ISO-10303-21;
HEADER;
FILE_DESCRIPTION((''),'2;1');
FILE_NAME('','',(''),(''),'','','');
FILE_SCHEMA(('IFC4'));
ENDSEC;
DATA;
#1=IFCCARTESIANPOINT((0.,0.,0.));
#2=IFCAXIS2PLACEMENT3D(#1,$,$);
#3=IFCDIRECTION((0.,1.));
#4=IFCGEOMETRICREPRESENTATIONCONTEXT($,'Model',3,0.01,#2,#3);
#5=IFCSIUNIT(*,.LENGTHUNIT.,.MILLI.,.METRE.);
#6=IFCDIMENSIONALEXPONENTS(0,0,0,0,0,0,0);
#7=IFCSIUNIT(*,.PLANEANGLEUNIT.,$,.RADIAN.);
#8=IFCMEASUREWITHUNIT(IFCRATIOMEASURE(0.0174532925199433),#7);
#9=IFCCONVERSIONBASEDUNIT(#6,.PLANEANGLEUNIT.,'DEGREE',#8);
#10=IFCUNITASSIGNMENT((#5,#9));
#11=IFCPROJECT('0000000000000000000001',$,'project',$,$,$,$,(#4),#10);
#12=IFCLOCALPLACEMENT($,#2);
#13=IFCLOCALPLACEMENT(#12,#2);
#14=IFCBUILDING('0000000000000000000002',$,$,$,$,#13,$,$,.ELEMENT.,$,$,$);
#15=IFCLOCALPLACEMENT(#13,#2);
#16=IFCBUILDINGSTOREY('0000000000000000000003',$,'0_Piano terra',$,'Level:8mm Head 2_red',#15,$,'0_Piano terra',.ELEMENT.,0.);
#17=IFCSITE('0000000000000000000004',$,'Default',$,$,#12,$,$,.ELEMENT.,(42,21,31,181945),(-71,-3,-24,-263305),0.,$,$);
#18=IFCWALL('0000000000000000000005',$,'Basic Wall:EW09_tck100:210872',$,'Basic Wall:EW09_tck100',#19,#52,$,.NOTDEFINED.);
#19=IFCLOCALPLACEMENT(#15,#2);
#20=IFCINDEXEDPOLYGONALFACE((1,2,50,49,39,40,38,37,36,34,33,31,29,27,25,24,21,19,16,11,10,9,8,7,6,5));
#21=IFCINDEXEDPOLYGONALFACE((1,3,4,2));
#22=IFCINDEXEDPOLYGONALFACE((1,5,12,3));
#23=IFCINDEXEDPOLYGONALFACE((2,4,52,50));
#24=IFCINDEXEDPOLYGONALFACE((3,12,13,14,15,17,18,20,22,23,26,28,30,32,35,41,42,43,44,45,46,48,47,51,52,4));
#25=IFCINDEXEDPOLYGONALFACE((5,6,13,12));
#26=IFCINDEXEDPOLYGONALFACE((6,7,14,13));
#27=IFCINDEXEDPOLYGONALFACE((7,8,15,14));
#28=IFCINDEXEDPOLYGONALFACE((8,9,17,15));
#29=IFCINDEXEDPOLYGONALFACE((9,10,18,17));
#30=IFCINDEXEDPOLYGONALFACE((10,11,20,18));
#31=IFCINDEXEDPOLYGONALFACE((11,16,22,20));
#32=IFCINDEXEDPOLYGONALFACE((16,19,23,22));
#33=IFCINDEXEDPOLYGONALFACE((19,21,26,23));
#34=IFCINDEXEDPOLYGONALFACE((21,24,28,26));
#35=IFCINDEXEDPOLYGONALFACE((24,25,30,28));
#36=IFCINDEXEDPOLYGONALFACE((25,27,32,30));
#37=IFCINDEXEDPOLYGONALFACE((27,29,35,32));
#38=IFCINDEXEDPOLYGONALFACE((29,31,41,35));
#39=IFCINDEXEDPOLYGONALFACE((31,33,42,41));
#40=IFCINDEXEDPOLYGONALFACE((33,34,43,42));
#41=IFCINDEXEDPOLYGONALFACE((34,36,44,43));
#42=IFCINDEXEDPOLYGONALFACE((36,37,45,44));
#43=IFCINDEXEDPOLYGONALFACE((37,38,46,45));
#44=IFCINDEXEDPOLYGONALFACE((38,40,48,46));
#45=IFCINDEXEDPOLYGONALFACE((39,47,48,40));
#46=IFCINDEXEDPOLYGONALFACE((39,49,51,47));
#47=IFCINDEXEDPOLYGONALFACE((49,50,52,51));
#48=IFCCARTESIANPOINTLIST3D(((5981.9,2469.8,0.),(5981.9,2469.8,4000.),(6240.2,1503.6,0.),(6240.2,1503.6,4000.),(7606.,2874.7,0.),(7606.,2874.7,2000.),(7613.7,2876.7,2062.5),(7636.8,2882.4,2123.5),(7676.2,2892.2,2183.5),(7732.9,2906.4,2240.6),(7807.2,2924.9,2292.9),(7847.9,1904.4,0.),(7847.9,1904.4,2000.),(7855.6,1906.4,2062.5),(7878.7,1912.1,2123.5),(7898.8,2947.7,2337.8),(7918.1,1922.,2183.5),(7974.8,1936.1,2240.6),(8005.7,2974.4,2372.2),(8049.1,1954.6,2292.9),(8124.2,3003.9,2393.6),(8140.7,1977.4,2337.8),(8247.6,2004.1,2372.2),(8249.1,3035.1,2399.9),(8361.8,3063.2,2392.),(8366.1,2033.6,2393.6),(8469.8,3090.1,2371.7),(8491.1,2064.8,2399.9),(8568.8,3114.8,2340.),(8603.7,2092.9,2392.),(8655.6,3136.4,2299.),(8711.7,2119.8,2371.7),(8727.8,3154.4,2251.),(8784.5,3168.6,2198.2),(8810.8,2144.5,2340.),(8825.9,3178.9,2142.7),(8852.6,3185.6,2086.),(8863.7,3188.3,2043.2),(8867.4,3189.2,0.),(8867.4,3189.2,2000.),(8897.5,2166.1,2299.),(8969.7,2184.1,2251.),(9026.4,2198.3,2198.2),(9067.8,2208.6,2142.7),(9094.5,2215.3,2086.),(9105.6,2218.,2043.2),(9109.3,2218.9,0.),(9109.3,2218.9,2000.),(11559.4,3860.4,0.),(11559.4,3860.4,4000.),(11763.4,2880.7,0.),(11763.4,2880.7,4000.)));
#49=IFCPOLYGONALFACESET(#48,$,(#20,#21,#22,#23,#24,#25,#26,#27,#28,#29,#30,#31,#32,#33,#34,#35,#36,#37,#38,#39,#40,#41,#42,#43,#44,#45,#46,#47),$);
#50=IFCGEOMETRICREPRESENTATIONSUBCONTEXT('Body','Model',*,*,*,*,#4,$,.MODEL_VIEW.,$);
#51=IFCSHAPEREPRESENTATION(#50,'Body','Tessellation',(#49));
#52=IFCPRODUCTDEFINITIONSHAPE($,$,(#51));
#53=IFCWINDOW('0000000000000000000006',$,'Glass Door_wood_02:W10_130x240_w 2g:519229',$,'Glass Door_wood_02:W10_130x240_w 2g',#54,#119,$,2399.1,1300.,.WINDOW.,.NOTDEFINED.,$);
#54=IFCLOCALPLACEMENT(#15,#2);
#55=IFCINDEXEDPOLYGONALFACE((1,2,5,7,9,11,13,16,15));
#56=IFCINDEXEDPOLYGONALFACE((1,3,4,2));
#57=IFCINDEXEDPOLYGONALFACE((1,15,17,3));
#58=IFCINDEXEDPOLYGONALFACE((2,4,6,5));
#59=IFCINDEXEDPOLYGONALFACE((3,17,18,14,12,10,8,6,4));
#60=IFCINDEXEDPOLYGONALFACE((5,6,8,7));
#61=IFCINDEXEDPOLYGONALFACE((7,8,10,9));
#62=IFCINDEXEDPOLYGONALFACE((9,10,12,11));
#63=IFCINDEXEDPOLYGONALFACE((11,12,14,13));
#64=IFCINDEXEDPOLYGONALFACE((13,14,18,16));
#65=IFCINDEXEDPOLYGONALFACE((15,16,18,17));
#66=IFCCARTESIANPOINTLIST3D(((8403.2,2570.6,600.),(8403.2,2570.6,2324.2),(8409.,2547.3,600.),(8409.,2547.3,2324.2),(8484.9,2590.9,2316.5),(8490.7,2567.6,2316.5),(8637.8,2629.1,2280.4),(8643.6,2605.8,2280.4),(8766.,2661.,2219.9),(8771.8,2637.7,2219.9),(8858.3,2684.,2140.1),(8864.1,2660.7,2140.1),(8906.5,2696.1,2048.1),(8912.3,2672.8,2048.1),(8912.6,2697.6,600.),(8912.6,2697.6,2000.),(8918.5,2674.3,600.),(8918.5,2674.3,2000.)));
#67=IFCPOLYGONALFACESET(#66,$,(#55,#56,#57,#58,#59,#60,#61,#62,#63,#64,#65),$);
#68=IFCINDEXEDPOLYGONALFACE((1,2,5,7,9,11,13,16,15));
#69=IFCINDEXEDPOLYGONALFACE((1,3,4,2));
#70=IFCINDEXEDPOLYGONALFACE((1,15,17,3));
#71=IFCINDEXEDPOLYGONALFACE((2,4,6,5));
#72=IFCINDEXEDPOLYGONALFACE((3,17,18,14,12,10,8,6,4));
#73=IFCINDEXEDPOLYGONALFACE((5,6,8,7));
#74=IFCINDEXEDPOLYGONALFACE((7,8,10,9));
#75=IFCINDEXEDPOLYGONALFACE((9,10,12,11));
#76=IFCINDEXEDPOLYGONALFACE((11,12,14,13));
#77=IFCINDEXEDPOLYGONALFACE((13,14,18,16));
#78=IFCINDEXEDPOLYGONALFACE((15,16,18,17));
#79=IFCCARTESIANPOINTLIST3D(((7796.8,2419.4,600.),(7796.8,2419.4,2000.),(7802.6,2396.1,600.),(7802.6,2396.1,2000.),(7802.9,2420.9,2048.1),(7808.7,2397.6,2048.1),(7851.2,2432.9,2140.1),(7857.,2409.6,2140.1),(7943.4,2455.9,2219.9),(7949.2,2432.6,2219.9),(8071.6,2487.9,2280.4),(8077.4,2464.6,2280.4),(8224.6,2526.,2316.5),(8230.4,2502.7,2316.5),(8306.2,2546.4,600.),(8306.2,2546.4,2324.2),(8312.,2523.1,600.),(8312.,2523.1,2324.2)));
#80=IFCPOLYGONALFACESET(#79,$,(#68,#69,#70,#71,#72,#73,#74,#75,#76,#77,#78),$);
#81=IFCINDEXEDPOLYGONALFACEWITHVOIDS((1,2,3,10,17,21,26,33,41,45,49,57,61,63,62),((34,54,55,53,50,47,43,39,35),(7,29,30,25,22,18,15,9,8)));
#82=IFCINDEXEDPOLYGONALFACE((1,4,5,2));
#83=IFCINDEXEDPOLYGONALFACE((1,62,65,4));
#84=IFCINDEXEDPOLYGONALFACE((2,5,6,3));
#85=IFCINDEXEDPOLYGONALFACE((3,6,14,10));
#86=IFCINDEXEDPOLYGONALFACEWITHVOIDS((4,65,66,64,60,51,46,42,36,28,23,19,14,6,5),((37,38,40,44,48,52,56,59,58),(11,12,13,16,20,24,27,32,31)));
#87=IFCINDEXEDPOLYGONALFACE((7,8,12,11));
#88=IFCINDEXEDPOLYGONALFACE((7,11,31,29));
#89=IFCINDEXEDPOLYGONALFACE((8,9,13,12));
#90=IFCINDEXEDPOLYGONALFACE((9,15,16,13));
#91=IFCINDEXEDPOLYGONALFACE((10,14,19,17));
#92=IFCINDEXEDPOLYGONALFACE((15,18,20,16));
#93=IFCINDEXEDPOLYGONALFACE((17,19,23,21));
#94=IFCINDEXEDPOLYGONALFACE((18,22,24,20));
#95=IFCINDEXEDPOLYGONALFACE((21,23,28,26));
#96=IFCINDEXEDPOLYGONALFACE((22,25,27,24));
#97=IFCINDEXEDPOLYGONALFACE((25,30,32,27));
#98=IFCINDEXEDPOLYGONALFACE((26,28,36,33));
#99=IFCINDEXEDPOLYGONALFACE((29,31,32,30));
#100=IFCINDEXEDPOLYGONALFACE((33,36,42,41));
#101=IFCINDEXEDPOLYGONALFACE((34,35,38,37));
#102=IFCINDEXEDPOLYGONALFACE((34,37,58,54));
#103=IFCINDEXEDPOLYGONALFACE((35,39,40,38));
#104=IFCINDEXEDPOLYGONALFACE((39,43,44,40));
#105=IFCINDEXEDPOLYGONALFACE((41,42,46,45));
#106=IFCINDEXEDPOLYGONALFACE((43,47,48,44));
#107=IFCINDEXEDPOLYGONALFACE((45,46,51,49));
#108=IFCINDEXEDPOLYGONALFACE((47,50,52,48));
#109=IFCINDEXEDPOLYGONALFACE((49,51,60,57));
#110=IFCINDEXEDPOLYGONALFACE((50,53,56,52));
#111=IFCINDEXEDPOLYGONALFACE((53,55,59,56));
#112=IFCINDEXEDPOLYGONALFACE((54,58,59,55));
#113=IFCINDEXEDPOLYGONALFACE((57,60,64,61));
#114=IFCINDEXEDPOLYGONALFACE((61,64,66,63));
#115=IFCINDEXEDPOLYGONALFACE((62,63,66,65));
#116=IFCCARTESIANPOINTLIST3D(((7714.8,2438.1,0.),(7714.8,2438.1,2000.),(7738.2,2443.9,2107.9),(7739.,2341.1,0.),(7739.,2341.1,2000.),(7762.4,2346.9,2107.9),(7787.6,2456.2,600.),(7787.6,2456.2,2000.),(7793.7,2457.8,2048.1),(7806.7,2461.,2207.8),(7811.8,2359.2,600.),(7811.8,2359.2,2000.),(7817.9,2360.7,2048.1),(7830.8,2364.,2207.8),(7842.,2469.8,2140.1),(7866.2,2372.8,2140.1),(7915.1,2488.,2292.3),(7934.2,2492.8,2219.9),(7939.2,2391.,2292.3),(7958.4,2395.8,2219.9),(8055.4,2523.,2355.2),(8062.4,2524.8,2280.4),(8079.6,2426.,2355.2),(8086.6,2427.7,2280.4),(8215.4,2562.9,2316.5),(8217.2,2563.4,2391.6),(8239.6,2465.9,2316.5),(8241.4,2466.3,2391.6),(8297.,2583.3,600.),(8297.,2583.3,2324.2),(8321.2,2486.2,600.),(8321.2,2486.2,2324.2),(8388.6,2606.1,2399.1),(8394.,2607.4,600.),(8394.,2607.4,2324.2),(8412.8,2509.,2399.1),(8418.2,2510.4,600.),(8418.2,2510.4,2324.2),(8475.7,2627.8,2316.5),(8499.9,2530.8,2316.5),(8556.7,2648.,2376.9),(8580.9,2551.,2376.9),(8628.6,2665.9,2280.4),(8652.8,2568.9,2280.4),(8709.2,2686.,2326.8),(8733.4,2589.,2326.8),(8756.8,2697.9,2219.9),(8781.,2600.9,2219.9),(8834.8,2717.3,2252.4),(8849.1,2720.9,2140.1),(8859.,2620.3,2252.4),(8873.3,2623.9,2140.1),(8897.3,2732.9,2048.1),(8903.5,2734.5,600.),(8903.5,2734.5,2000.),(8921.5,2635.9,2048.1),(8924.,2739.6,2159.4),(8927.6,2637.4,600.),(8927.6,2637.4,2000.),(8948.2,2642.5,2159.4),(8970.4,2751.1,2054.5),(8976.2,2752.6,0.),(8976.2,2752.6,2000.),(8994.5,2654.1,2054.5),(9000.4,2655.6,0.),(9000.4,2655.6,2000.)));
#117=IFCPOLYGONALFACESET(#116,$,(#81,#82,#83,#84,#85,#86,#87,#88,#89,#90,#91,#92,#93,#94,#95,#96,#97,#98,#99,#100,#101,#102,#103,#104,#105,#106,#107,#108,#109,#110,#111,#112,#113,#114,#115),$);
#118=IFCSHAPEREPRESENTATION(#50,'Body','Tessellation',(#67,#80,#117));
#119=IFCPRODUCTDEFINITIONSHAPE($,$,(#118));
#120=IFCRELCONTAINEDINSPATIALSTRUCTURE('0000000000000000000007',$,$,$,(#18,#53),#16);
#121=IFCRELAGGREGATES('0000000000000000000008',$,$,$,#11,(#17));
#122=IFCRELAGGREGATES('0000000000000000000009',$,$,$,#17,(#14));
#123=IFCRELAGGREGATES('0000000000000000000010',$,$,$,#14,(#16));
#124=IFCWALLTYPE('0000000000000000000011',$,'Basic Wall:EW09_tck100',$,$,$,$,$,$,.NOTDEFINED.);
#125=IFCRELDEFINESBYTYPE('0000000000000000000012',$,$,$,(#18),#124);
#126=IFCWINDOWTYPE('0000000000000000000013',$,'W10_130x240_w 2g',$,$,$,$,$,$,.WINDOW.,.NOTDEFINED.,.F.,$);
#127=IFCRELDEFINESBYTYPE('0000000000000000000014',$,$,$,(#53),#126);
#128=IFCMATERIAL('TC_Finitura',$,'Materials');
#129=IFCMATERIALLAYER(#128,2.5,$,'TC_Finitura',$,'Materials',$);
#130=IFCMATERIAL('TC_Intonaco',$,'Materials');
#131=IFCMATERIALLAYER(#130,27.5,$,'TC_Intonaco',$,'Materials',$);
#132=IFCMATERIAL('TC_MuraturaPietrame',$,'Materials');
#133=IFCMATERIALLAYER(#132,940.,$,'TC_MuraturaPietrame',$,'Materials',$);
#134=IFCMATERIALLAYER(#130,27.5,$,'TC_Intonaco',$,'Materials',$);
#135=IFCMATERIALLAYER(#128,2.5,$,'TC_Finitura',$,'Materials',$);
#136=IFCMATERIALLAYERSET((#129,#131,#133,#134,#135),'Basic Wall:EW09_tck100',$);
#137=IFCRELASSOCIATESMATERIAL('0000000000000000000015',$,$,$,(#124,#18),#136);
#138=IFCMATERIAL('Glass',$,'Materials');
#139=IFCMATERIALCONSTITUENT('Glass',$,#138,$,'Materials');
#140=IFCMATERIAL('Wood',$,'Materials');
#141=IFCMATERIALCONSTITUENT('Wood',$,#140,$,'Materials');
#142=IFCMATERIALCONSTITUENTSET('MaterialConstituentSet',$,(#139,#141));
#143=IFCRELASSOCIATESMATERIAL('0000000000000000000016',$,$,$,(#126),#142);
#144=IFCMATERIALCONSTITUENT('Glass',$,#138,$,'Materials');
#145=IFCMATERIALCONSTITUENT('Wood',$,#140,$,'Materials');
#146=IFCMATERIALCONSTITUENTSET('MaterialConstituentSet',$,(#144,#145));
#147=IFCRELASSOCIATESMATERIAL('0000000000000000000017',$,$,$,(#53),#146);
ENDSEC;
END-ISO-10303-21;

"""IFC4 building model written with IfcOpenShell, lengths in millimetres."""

from ifc_helpers import new_model, entity, si_unit, converted_unit, direction, frame, frame_2d, origin, place, context, subcontext, project, spatial, polyline, ellipse_curve, parameter, trimmed, segment, composite_curve, outline, extrude, clip, bounded_halfspace, source, transform, mapped, material, layer, layer_set, layer_usage, constituent, constituent_set, type_object, type_shapes, element, fill, save


model = new_model("IFC4")

# Units and contexts
model_context = context("Model", 3, precision=0.01, world=origin(), true_north=direction((0.0, 1.0)))
body_context = subcontext(model_context, "Body", "Model", "MODEL_VIEW")
ifc_project = project(units=[si_unit("LENGTHUNIT", "METRE", prefix="MILLI"), converted_unit("PLANEANGLEUNIT", "DEGREE", entity("IfcRatioMeasure", 0.0174532925199433), si_unit("PLANEANGLEUNIT", "RADIAN"), dimensions=[0, 0, 0, 0, 0, 0, 0])], contexts=[model_context])

# Site, building, storey
site_placement = place(None, origin())
site = spatial("IfcSite", under=ifc_project, at=site_placement, Name="Default", CompositionType="ELEMENT", RefLatitude=(42, 21, 31, 181945), RefLongitude=(-71, -3, -24, -263305), RefElevation=0.0)
building_placement = place(site_placement, origin())
building = spatial("IfcBuilding", under=site, at=building_placement, CompositionType="ELEMENT")
storey_placement = place(building_placement, origin())
storey = spatial("IfcBuildingStorey", under=building, at=storey_placement, Name="0_Piano terra", ObjectType="Level:8mm Head 2_red", LongName="0_Piano terra", CompositionType="ELEMENT", Elevation=0.0)

# Shared definitions
ifc_material_1 = material(Name="TC_Finitura", Category="Materials")
ifc_material_2 = material(Name="TC_Intonaco", Category="Materials")
ifc_material_3 = material(Name="TC_MuraturaPietrame", Category="Materials")
ifc_material_4 = material(Name="Glass", Category="Materials")
ifc_material_5 = material(Name="Wood", Category="Materials")

# Wall, opening, window
ifc_layer_1 = layer(ifc_material_1, 2.5, Name="TC_Finitura", Category="Materials")
ifc_layer_2 = layer(ifc_material_2, 27.5, Name="TC_Intonaco", Category="Materials")
ifc_layer_3 = layer(ifc_material_3, 940.0, Name="TC_MuraturaPietrame", Category="Materials")
ifc_layer_4 = layer(ifc_material_2, 27.5, Name="TC_Intonaco", Category="Materials")
ifc_layer_5 = layer(ifc_material_1, 2.5, Name="TC_Finitura", Category="Materials")
ifc_layer_set_1 = layer_set([ifc_layer_1, ifc_layer_2, ifc_layer_3, ifc_layer_4, ifc_layer_5], Name="Basic Wall:EW09_tck100")
ifc_layer_usage_1 = layer_usage(ifc_layer_set_1, "AXIS2", "NEGATIVE", 500.0)
wall_type_1 = type_object("IfcWallType", Name="Basic Wall:EW09_tck100", PredefinedType="NOTDEFINED", material=ifc_layer_set_1)
wall_1_placement = place(storey_placement, frame((6102.9, 1984.7, 0.0), z_axis=(0.0, 0.0, 1.0), x_axis=(0.970296, 0.241922, 0.0)))
wall_1 = element("IfcWall", 1, at=wall_1_placement, inside=storey, type_object=wall_type_1, material=ifc_layer_usage_1, Name="Basic Wall:EW09_tck100:210872", ObjectType="Basic Wall:EW09_tck100", PredefinedType="NOTDEFINED", context=body_context, shape_type="Clipping", body=[
    clip(extrude(outline(polyline([(16.8, -500.0), (5709.1, -500.0), (5740.5, 301.2), (5748.3, 500.0), (5047.7, 500.0), (0.0, 500.0), (16.8, -500.0)])), origin(), (0.0, 0.0, 1.0), 4000.0), bounded_halfspace(frame((16.8, -500.0, 4000.0), z_axis=(0.0, 0.0, -1.0), x_axis=(0.034271, -0.999413, 0.0)), True, frame((16.8, -500.0, 4000.0)), polyline([(0.0, 0.0), (5692.3, 0.0), (5723.7, 801.2), (5731.4, 1000.0), (5030.9, 1000.0), (-16.8, 1000.0), (0.0, 0.0)]))),
])
opening_1_placement = place(wall_1_placement, frame((1673.8, -500.0, 0.0)))
opening_1 = element("IfcOpeningElement", 2, at=opening_1_placement, cuts=wall_1, ObjectType="Opening", PredefinedType="OPENING", context=body_context, shape_type="SweptSolid", body=[
    extrude(outline(composite_curve([segment(polyline([(0.0, 1300.0), (0.0, 0.0)]), True, "CONTINUOUS"), segment(polyline([(0.0, 0.0), (2000.0, 0.0)]), True, "CONTINUOUS"), segment(trimmed(ellipse_curve(frame_2d((2000.0, 650.0), x_axis=(0.0, 1.0)), 650.0, 400.0), [parameter(180.0)], [parameter(360.0)], True, "PARAMETER"), True, "CONTINUOUS"), segment(polyline([(2000.0, 1300.0), (0.0, 1300.0)]), True, "CONTINUOUS")], self_intersect=False)), frame((0.0, 0.0, 0.0), z_axis=(0.0, 1.0, 0.0), x_axis=(0.0, 0.0, 1.0)), (0.0, 0.0, 1.0), 1000.0),
])
ifc_constituent_1 = constituent(ifc_material_4, Name="Glass", Category="Materials")
ifc_constituent_2 = constituent(ifc_material_5, Name="Wood", Category="Materials")
ifc_constituent_set_1 = constituent_set(constituents=[ifc_constituent_1, ifc_constituent_2], Name="MaterialConstituentSet")
ifc_constituent_3 = constituent(ifc_material_4, Name="Glass", Category="Materials")
ifc_constituent_4 = constituent(ifc_material_5, Name="Wood", Category="Materials")
ifc_constituent_set_2 = constituent_set(constituents=[ifc_constituent_3, ifc_constituent_4], Name="MaterialConstituentSet")
window_type_1 = type_object("IfcWindowType", Name="W10_130x240_w 2g", ParameterTakesPrecedence=False, PartitioningType="NOTDEFINED", PredefinedType="WINDOW", material=ifc_constituent_set_2)
shared_shape_1 = source(origin(), body_context, "Body", "SweptSolid", [
    extrude(outline(polyline([(-347.6, -457.7), (-263.1, -457.7), (-102.8, -436.3), (34.3, -388.1), (136.3, -317.4), (194.2, -230.3), (204.9, -183.0), (333.3, 1211.1), (-189.5, 1259.3), (-347.6, -457.7)])), frame((1004.2, 488.0, 1836.6), z_axis=(0.0, 1.0, 0.0), x_axis=(0.995788, 0.0, -0.091683)), (0.0, 0.0, 1.0), 24.0),
    extrude(outline(polyline([(133.3, -240.2), (181.8, -240.2), (279.5, -202.9), (371.0, -119.0), (448.2, 4.1), (504.5, 155.7), (523.1, 238.1), (-1186.5, 462.6), (-1254.8, -58.0), (133.3, -240.2)])), frame((295.8, 488.0, 1836.6), z_axis=(0.0, 1.0, 0.0), x_axis=(0.130191, 0.0, 0.991489)), (0.0, 0.0, 1.0), 24.0),
    extrude(outline(polyline([(-628.3, -1928.3), (671.7, -1928.3), (671.7, 71.7), (647.6, 179.7), (577.0, 279.6), (465.3, 364.1), (320.7, 426.9), (153.9, 463.4), (-22.7, 470.8), (-196.0, 448.6), (-353.2, 398.5), (-482.5, 324.2), (-574.5, 231.1), (-622.3, 126.2), (-628.3, 71.7), (-628.3, -1928.3)]), holes=[polyline([(-553.3, -1328.3), (-553.3, 71.7), (-547.0, 119.9), (-497.3, 211.9), (-402.2, 291.6), (-270.1, 352.2), (-112.5, 388.2), (-28.3, 396.0), (-28.3, -1328.3), (-553.3, -1328.3)]), polyline([(596.7, -1328.3), (71.7, -1328.3), (71.7, 396.0), (155.8, 388.2), (313.4, 352.2), (445.6, 291.6), (540.6, 211.9), (590.3, 119.9), (596.7, 71.7), (596.7, -1328.3)])]), frame((671.7, 450.0, 1928.3), z_axis=(0.0, 1.0, 0.0), x_axis=(-1.0, 0.0, 0.0)), (0.0, 0.0, 1.0), 100.0),
])
type_shapes(window_type_1, [shared_shape_1])
window_1_placement = place(opening_1_placement, origin())
window_1 = element("IfcWindow", 3, at=window_1_placement, inside=storey, type_object=window_type_1, material=ifc_constituent_set_1, Name="Glass Door_wood_02:W10_130x240_w 2g:519229", ObjectType="Glass Door_wood_02:W10_130x240_w 2g", OverallHeight=2399.1, OverallWidth=1300.0, PartitioningType="NOTDEFINED", PredefinedType="WINDOW", context=body_context, shape_type="MappedRepresentation", body=[
    mapped(shared_shape_1, transform((0.0, 0.0, 0.0), scale=1.0)),
])
fill(opening_1, window_1)

save(model, "model.ifc")
